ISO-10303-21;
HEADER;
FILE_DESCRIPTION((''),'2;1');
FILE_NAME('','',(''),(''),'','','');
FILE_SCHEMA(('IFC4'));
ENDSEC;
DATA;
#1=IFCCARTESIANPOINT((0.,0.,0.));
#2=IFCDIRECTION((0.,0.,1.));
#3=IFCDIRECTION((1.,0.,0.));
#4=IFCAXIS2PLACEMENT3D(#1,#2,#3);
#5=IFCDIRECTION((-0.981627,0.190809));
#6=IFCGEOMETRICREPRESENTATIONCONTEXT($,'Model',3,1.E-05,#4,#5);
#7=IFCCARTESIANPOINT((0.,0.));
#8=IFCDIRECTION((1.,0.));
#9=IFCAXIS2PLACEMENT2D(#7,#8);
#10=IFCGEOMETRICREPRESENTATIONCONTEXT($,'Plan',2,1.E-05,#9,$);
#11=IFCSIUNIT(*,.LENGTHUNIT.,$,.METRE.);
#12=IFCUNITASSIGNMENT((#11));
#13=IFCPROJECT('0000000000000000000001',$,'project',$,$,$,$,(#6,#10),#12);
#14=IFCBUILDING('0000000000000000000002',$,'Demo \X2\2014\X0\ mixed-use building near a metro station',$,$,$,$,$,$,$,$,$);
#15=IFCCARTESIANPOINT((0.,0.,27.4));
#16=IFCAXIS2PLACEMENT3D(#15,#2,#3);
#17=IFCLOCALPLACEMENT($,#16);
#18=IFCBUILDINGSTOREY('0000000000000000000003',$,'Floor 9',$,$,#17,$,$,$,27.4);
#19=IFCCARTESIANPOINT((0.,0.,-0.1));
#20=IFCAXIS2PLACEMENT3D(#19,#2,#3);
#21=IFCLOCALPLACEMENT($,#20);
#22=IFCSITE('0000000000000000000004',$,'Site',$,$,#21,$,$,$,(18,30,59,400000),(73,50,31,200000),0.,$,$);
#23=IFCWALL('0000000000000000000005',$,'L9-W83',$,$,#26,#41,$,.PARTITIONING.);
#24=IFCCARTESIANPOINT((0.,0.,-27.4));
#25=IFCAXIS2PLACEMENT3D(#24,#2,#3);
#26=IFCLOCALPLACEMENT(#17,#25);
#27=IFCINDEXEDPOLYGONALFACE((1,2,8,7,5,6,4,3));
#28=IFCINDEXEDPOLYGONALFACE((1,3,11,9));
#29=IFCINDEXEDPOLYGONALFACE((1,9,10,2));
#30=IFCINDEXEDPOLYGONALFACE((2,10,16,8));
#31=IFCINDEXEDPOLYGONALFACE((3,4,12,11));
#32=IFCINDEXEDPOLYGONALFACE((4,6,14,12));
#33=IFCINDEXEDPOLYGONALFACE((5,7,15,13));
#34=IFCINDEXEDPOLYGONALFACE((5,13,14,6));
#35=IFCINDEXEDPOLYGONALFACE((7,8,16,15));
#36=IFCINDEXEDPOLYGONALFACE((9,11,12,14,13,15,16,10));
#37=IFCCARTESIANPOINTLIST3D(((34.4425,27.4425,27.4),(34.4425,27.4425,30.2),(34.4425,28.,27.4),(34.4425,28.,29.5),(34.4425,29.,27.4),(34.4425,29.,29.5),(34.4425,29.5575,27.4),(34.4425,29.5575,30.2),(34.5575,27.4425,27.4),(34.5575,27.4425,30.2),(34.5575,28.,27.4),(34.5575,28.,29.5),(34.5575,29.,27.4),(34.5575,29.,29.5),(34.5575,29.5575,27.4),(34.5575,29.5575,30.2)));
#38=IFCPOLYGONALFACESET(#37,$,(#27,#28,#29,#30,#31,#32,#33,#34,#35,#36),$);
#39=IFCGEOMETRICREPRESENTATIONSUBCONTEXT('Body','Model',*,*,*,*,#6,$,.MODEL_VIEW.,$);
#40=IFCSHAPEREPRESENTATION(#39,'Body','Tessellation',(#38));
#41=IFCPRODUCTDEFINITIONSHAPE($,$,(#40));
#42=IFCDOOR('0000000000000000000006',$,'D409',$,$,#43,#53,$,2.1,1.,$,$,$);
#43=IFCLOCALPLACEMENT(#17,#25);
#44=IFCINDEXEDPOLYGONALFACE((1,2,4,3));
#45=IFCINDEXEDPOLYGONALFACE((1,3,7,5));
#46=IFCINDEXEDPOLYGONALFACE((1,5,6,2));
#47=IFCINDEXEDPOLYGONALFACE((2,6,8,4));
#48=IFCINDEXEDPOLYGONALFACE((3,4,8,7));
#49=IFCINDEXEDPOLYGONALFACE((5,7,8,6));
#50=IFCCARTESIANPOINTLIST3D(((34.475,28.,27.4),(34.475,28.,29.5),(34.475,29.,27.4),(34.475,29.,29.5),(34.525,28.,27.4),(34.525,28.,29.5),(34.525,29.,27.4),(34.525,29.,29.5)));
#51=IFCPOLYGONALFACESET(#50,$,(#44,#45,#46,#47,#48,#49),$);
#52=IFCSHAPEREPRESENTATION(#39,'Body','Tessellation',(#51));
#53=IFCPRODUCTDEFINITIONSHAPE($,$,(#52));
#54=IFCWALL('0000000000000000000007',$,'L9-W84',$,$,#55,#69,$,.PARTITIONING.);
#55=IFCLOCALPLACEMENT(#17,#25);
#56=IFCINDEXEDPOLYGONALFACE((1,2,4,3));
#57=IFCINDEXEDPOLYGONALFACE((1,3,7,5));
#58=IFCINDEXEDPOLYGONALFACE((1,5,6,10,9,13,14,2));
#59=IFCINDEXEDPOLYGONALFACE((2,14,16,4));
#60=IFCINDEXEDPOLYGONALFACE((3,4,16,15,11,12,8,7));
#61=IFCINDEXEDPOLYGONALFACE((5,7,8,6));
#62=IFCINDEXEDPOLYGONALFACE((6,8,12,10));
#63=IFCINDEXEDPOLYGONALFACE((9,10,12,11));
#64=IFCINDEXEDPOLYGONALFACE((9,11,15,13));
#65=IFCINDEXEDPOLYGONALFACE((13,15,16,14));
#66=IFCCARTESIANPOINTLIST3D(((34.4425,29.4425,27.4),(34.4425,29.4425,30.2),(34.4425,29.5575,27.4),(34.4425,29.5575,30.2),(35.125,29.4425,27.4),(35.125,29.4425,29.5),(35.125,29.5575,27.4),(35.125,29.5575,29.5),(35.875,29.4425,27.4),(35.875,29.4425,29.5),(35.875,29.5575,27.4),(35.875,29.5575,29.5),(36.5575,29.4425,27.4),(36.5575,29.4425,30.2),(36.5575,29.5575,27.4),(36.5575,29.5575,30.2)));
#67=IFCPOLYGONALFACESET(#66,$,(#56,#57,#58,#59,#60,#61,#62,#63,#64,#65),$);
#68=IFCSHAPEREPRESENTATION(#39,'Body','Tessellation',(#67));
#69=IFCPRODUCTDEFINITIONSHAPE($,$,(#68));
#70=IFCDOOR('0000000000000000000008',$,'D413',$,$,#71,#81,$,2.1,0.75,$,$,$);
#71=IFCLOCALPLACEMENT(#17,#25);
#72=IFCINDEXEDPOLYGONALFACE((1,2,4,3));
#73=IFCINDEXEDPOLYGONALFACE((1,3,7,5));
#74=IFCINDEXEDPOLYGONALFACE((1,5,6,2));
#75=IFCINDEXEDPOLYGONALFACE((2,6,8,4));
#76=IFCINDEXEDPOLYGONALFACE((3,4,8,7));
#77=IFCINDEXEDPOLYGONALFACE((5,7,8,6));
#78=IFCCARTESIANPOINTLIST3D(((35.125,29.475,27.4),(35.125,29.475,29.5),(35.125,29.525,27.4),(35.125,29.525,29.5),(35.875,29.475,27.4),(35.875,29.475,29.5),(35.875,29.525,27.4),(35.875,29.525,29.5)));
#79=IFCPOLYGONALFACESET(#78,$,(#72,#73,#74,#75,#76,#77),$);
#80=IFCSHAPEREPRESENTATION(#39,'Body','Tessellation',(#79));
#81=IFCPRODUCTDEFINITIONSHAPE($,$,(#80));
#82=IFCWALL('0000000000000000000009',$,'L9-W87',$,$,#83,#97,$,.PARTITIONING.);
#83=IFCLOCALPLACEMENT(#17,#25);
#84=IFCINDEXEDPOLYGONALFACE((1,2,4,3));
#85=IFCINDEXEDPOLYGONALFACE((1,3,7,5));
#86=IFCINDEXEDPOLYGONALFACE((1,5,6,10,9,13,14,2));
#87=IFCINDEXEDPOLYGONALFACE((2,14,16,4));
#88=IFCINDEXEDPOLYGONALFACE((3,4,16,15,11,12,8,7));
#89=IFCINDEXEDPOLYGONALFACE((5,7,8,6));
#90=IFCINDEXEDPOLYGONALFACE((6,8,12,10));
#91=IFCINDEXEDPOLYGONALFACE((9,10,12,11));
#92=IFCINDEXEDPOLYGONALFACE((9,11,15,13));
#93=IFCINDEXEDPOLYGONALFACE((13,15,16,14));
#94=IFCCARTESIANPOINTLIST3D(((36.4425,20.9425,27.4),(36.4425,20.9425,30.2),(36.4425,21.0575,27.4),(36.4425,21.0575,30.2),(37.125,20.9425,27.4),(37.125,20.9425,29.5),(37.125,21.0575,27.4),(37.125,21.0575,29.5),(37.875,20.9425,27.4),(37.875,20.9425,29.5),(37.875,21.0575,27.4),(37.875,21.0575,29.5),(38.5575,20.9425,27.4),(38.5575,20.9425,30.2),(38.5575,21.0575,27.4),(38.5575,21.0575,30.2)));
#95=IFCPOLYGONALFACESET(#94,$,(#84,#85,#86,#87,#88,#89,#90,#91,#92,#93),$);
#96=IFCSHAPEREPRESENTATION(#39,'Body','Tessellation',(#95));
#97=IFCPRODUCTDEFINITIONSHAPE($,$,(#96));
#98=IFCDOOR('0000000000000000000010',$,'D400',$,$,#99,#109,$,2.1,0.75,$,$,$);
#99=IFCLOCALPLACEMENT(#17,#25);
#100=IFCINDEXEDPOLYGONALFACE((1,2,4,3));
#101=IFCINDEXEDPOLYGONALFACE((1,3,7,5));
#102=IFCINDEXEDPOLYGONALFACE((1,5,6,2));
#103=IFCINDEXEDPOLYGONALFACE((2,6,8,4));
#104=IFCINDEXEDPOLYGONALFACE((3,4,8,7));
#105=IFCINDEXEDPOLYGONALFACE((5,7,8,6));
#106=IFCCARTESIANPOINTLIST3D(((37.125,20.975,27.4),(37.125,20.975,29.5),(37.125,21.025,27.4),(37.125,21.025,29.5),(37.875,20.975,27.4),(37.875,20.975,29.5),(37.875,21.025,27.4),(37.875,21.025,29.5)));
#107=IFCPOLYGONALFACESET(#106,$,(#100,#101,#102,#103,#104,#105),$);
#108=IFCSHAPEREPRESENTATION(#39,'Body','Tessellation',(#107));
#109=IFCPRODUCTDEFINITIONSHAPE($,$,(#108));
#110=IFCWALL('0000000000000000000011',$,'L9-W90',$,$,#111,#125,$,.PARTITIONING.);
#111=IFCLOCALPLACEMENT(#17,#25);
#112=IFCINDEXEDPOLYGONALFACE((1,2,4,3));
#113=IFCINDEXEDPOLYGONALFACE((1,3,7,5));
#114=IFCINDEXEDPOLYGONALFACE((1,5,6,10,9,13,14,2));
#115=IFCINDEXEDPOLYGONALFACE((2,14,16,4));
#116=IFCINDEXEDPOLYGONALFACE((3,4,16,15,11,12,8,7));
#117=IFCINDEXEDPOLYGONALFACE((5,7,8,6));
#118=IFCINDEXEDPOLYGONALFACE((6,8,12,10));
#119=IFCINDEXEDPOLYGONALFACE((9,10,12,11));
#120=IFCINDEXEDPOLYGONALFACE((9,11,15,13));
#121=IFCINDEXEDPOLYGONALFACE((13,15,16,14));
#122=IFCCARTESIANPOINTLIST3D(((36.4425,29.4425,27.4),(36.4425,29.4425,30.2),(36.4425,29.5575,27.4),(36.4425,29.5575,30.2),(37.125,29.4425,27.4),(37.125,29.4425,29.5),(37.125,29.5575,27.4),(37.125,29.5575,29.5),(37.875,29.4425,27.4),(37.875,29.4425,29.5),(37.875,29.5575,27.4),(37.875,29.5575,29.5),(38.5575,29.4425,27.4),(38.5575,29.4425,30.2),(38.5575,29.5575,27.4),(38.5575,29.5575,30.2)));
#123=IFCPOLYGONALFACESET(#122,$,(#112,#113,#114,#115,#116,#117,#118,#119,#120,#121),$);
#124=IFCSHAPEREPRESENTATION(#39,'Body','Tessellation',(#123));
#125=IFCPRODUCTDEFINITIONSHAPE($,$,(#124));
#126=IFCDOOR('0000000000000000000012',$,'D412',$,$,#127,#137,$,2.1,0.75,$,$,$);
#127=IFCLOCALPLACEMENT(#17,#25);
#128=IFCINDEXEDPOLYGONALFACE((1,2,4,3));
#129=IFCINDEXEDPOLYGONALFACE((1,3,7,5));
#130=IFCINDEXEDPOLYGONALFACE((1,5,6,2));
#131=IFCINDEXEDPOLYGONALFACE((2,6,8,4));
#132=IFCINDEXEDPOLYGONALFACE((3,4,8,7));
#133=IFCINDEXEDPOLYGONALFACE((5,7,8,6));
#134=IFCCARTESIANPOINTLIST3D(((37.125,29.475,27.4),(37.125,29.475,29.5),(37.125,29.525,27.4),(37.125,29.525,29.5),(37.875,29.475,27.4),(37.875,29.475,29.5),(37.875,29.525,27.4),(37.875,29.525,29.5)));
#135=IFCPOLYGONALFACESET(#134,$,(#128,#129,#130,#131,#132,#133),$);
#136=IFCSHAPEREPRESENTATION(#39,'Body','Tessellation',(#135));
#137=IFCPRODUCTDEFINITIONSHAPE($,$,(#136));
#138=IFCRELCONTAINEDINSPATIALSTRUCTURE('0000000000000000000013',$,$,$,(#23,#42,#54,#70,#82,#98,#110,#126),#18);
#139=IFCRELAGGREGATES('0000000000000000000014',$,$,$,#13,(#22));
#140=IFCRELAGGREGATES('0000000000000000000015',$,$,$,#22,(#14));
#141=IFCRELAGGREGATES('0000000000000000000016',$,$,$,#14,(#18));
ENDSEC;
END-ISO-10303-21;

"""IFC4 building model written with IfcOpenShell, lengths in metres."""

from ifc_helpers import new_model, si_unit, direction, frame, origin_with_axes, origin_2d_with_axis, place, context, subcontext, project, spatial, line, indexed_curve, outline, extrude, element, fill, save


model = new_model("IFC4")

# Units and contexts
model_context = context("Model", 3, precision=1e-05, world=origin_with_axes(), true_north=direction((-0.981627, 0.190809)))
plan_context = context("Plan", 2, precision=1e-05, world=origin_2d_with_axis())
body_context = subcontext(model_context, "Body", "Model", "MODEL_VIEW")
ifc_project = project(units=[si_unit("LENGTHUNIT", "METRE")], contexts=[model_context, plan_context])

# Site, building, storey
site_placement = place(None, frame((0.0, 0.0, -0.1), z_axis=(0.0, 0.0, 1.0), x_axis=(1.0, 0.0, 0.0)))
site = spatial("IfcSite", under=ifc_project, at=site_placement, Name="Site", RefLatitude=(18, 30, 59, 400000), RefLongitude=(73, 50, 31, 200000), RefElevation=0.0)
building = spatial("IfcBuilding", under=site, Name="Demo — mixed-use building near a metro station")
storey_placement = place(None, frame((0.0, 0.0, 27.4), z_axis=(0.0, 0.0, 1.0), x_axis=(1.0, 0.0, 0.0)))
storey = spatial("IfcBuildingStorey", under=building, at=storey_placement, Name="Floor 9", Elevation=27.4)

# Walls, openings, doors
wall_1_placement = place(storey_placement, frame((0.0, 0.0, -27.4), z_axis=(0.0, 0.0, 1.0), x_axis=(1.0, 0.0, 0.0)))
wall_1 = element("IfcWall", 1, at=wall_1_placement, inside=storey, Name="L9-W83", PredefinedType="PARTITIONING", context=body_context, shape_type="SweptSolid", body=[
    extrude(outline(indexed_curve([(34.4425, 27.4425), (34.4425, 29.5575), (34.5575, 29.5575), (34.5575, 27.4425)], segments=[line(1, 2, 3, 4, 1)])), frame((0.0, 0.0, 27.4), z_axis=(0.0, 0.0, 1.0), x_axis=(1.0, 0.0, 0.0)), (0.0, 0.0, 1.0), 2.8),
])
opening_1_placement = place(wall_1_placement, origin_with_axes())
opening_1 = element("IfcOpeningElement", 2, at=opening_1_placement, cuts=wall_1, context=body_context, shape_type="SweptSolid", body=[
    extrude(outline(indexed_curve([(34.3925, 28.0), (34.3925, 29.0), (34.6075, 29.0), (34.6075, 28.0)], segments=[line(1, 2, 3, 4, 1)])), frame((0.0, 0.0, 27.4), z_axis=(0.0, 0.0, 1.0), x_axis=(1.0, 0.0, 0.0)), (0.0, 0.0, 1.0), 2.1),
])
door_1_placement = place(storey_placement, frame((0.0, 0.0, -27.4), z_axis=(0.0, 0.0, 1.0), x_axis=(1.0, 0.0, 0.0)))
door_1 = element("IfcDoor", 3, at=door_1_placement, inside=storey, Name="D409", OverallHeight=2.1, OverallWidth=1.0, context=body_context, shape_type="SweptSolid", body=[
    extrude(outline(indexed_curve([(34.475, 28.0), (34.475, 29.0), (34.525, 29.0), (34.525, 28.0)], segments=[line(1, 2, 3, 4, 1)])), frame((0.0, 0.0, 27.4), z_axis=(0.0, 0.0, 1.0), x_axis=(1.0, 0.0, 0.0)), (0.0, 0.0, 1.0), 2.1),
])
fill(opening_1, door_1)
wall_2_placement = place(storey_placement, frame((0.0, 0.0, -27.4), z_axis=(0.0, 0.0, 1.0), x_axis=(1.0, 0.0, 0.0)))
wall_2 = element("IfcWall", 4, at=wall_2_placement, inside=storey, Name="L9-W84", PredefinedType="PARTITIONING", context=body_context, shape_type="SweptSolid", body=[
    extrude(outline(indexed_curve([(36.5575, 29.4425), (34.4425, 29.4425), (34.4425, 29.5575), (36.5575, 29.5575)], segments=[line(1, 2, 3, 4, 1)])), frame((0.0, 0.0, 27.4), z_axis=(0.0, 0.0, 1.0), x_axis=(1.0, 0.0, 0.0)), (0.0, 0.0, 1.0), 2.8),
])
opening_2_placement = place(wall_2_placement, origin_with_axes())
opening_2 = element("IfcOpeningElement", 5, at=opening_2_placement, cuts=wall_2, context=body_context, shape_type="SweptSolid", body=[
    extrude(outline(indexed_curve([(35.875, 29.3925), (35.125, 29.3925), (35.125, 29.6075), (35.875, 29.6075)], segments=[line(1, 2, 3, 4, 1)])), frame((0.0, 0.0, 27.4), z_axis=(0.0, 0.0, 1.0), x_axis=(1.0, 0.0, 0.0)), (0.0, 0.0, 1.0), 2.1),
])
door_2_placement = place(storey_placement, frame((0.0, 0.0, -27.4), z_axis=(0.0, 0.0, 1.0), x_axis=(1.0, 0.0, 0.0)))
door_2 = element("IfcDoor", 6, at=door_2_placement, inside=storey, Name="D413", OverallHeight=2.1, OverallWidth=0.75, context=body_context, shape_type="SweptSolid", body=[
    extrude(outline(indexed_curve([(35.875, 29.475), (35.125, 29.475), (35.125, 29.525), (35.875, 29.525)], segments=[line(1, 2, 3, 4, 1)])), frame((0.0, 0.0, 27.4), z_axis=(0.0, 0.0, 1.0), x_axis=(1.0, 0.0, 0.0)), (0.0, 0.0, 1.0), 2.1),
])
fill(opening_2, door_2)

# Wall, opening, door
wall_3_placement = place(storey_placement, frame((0.0, 0.0, -27.4), z_axis=(0.0, 0.0, 1.0), x_axis=(1.0, 0.0, 0.0)))
wall_3 = element("IfcWall", 7, at=wall_3_placement, inside=storey, Name="L9-W87", PredefinedType="PARTITIONING", context=body_context, shape_type="SweptSolid", body=[
    extrude(outline(indexed_curve([(38.5575, 20.9425), (36.4425, 20.9425), (36.4425, 21.0575), (38.5575, 21.0575)], segments=[line(1, 2, 3, 4, 1)])), frame((0.0, 0.0, 27.4), z_axis=(0.0, 0.0, 1.0), x_axis=(1.0, 0.0, 0.0)), (0.0, 0.0, 1.0), 2.8),
])
opening_3_placement = place(wall_3_placement, origin_with_axes())
opening_3 = element("IfcOpeningElement", 8, at=opening_3_placement, cuts=wall_3, context=body_context, shape_type="SweptSolid", body=[
    extrude(outline(indexed_curve([(37.875, 20.8925), (37.125, 20.8925), (37.125, 21.1075), (37.875, 21.1075)], segments=[line(1, 2, 3, 4, 1)])), frame((0.0, 0.0, 27.4), z_axis=(0.0, 0.0, 1.0), x_axis=(1.0, 0.0, 0.0)), (0.0, 0.0, 1.0), 2.1),
])
door_3_placement = place(storey_placement, frame((0.0, 0.0, -27.4), z_axis=(0.0, 0.0, 1.0), x_axis=(1.0, 0.0, 0.0)))
door_3 = element("IfcDoor", 9, at=door_3_placement, inside=storey, Name="D400", OverallHeight=2.1, OverallWidth=0.75, context=body_context, shape_type="SweptSolid", body=[
    extrude(outline(indexed_curve([(37.875, 20.975), (37.125, 20.975), (37.125, 21.025), (37.875, 21.025)], segments=[line(1, 2, 3, 4, 1)])), frame((0.0, 0.0, 27.4), z_axis=(0.0, 0.0, 1.0), x_axis=(1.0, 0.0, 0.0)), (0.0, 0.0, 1.0), 2.1),
])
fill(opening_3, door_3)

# Wall, opening, door
wall_4_placement = place(storey_placement, frame((0.0, 0.0, -27.4), z_axis=(0.0, 0.0, 1.0), x_axis=(1.0, 0.0, 0.0)))
wall_4 = element("IfcWall", 10, at=wall_4_placement, inside=storey, Name="L9-W90", PredefinedType="PARTITIONING", context=body_context, shape_type="SweptSolid", body=[
    extrude(outline(indexed_curve([(38.5575, 29.4425), (36.4425, 29.4425), (36.4425, 29.5575), (38.5575, 29.5575)], segments=[line(1, 2, 3, 4, 1)])), frame((0.0, 0.0, 27.4), z_axis=(0.0, 0.0, 1.0), x_axis=(1.0, 0.0, 0.0)), (0.0, 0.0, 1.0), 2.8),
])
opening_4_placement = place(wall_4_placement, origin_with_axes())
opening_4 = element("IfcOpeningElement", 11, at=opening_4_placement, cuts=wall_4, context=body_context, shape_type="SweptSolid", body=[
    extrude(outline(indexed_curve([(37.875, 29.3925), (37.125, 29.3925), (37.125, 29.6075), (37.875, 29.6075)], segments=[line(1, 2, 3, 4, 1)])), frame((0.0, 0.0, 27.4), z_axis=(0.0, 0.0, 1.0), x_axis=(1.0, 0.0, 0.0)), (0.0, 0.0, 1.0), 2.1),
])
door_4_placement = place(storey_placement, frame((0.0, 0.0, -27.4), z_axis=(0.0, 0.0, 1.0), x_axis=(1.0, 0.0, 0.0)))
door_4 = element("IfcDoor", 12, at=door_4_placement, inside=storey, Name="D412", OverallHeight=2.1, OverallWidth=0.75, context=body_context, shape_type="SweptSolid", body=[
    extrude(outline(indexed_curve([(37.875, 29.475), (37.125, 29.475), (37.125, 29.525), (37.875, 29.525)], segments=[line(1, 2, 3, 4, 1)])), frame((0.0, 0.0, 27.4), z_axis=(0.0, 0.0, 1.0), x_axis=(1.0, 0.0, 0.0)), (0.0, 0.0, 1.0), 2.1),
])
fill(opening_4, door_4)

save(model, "model.ifc")
